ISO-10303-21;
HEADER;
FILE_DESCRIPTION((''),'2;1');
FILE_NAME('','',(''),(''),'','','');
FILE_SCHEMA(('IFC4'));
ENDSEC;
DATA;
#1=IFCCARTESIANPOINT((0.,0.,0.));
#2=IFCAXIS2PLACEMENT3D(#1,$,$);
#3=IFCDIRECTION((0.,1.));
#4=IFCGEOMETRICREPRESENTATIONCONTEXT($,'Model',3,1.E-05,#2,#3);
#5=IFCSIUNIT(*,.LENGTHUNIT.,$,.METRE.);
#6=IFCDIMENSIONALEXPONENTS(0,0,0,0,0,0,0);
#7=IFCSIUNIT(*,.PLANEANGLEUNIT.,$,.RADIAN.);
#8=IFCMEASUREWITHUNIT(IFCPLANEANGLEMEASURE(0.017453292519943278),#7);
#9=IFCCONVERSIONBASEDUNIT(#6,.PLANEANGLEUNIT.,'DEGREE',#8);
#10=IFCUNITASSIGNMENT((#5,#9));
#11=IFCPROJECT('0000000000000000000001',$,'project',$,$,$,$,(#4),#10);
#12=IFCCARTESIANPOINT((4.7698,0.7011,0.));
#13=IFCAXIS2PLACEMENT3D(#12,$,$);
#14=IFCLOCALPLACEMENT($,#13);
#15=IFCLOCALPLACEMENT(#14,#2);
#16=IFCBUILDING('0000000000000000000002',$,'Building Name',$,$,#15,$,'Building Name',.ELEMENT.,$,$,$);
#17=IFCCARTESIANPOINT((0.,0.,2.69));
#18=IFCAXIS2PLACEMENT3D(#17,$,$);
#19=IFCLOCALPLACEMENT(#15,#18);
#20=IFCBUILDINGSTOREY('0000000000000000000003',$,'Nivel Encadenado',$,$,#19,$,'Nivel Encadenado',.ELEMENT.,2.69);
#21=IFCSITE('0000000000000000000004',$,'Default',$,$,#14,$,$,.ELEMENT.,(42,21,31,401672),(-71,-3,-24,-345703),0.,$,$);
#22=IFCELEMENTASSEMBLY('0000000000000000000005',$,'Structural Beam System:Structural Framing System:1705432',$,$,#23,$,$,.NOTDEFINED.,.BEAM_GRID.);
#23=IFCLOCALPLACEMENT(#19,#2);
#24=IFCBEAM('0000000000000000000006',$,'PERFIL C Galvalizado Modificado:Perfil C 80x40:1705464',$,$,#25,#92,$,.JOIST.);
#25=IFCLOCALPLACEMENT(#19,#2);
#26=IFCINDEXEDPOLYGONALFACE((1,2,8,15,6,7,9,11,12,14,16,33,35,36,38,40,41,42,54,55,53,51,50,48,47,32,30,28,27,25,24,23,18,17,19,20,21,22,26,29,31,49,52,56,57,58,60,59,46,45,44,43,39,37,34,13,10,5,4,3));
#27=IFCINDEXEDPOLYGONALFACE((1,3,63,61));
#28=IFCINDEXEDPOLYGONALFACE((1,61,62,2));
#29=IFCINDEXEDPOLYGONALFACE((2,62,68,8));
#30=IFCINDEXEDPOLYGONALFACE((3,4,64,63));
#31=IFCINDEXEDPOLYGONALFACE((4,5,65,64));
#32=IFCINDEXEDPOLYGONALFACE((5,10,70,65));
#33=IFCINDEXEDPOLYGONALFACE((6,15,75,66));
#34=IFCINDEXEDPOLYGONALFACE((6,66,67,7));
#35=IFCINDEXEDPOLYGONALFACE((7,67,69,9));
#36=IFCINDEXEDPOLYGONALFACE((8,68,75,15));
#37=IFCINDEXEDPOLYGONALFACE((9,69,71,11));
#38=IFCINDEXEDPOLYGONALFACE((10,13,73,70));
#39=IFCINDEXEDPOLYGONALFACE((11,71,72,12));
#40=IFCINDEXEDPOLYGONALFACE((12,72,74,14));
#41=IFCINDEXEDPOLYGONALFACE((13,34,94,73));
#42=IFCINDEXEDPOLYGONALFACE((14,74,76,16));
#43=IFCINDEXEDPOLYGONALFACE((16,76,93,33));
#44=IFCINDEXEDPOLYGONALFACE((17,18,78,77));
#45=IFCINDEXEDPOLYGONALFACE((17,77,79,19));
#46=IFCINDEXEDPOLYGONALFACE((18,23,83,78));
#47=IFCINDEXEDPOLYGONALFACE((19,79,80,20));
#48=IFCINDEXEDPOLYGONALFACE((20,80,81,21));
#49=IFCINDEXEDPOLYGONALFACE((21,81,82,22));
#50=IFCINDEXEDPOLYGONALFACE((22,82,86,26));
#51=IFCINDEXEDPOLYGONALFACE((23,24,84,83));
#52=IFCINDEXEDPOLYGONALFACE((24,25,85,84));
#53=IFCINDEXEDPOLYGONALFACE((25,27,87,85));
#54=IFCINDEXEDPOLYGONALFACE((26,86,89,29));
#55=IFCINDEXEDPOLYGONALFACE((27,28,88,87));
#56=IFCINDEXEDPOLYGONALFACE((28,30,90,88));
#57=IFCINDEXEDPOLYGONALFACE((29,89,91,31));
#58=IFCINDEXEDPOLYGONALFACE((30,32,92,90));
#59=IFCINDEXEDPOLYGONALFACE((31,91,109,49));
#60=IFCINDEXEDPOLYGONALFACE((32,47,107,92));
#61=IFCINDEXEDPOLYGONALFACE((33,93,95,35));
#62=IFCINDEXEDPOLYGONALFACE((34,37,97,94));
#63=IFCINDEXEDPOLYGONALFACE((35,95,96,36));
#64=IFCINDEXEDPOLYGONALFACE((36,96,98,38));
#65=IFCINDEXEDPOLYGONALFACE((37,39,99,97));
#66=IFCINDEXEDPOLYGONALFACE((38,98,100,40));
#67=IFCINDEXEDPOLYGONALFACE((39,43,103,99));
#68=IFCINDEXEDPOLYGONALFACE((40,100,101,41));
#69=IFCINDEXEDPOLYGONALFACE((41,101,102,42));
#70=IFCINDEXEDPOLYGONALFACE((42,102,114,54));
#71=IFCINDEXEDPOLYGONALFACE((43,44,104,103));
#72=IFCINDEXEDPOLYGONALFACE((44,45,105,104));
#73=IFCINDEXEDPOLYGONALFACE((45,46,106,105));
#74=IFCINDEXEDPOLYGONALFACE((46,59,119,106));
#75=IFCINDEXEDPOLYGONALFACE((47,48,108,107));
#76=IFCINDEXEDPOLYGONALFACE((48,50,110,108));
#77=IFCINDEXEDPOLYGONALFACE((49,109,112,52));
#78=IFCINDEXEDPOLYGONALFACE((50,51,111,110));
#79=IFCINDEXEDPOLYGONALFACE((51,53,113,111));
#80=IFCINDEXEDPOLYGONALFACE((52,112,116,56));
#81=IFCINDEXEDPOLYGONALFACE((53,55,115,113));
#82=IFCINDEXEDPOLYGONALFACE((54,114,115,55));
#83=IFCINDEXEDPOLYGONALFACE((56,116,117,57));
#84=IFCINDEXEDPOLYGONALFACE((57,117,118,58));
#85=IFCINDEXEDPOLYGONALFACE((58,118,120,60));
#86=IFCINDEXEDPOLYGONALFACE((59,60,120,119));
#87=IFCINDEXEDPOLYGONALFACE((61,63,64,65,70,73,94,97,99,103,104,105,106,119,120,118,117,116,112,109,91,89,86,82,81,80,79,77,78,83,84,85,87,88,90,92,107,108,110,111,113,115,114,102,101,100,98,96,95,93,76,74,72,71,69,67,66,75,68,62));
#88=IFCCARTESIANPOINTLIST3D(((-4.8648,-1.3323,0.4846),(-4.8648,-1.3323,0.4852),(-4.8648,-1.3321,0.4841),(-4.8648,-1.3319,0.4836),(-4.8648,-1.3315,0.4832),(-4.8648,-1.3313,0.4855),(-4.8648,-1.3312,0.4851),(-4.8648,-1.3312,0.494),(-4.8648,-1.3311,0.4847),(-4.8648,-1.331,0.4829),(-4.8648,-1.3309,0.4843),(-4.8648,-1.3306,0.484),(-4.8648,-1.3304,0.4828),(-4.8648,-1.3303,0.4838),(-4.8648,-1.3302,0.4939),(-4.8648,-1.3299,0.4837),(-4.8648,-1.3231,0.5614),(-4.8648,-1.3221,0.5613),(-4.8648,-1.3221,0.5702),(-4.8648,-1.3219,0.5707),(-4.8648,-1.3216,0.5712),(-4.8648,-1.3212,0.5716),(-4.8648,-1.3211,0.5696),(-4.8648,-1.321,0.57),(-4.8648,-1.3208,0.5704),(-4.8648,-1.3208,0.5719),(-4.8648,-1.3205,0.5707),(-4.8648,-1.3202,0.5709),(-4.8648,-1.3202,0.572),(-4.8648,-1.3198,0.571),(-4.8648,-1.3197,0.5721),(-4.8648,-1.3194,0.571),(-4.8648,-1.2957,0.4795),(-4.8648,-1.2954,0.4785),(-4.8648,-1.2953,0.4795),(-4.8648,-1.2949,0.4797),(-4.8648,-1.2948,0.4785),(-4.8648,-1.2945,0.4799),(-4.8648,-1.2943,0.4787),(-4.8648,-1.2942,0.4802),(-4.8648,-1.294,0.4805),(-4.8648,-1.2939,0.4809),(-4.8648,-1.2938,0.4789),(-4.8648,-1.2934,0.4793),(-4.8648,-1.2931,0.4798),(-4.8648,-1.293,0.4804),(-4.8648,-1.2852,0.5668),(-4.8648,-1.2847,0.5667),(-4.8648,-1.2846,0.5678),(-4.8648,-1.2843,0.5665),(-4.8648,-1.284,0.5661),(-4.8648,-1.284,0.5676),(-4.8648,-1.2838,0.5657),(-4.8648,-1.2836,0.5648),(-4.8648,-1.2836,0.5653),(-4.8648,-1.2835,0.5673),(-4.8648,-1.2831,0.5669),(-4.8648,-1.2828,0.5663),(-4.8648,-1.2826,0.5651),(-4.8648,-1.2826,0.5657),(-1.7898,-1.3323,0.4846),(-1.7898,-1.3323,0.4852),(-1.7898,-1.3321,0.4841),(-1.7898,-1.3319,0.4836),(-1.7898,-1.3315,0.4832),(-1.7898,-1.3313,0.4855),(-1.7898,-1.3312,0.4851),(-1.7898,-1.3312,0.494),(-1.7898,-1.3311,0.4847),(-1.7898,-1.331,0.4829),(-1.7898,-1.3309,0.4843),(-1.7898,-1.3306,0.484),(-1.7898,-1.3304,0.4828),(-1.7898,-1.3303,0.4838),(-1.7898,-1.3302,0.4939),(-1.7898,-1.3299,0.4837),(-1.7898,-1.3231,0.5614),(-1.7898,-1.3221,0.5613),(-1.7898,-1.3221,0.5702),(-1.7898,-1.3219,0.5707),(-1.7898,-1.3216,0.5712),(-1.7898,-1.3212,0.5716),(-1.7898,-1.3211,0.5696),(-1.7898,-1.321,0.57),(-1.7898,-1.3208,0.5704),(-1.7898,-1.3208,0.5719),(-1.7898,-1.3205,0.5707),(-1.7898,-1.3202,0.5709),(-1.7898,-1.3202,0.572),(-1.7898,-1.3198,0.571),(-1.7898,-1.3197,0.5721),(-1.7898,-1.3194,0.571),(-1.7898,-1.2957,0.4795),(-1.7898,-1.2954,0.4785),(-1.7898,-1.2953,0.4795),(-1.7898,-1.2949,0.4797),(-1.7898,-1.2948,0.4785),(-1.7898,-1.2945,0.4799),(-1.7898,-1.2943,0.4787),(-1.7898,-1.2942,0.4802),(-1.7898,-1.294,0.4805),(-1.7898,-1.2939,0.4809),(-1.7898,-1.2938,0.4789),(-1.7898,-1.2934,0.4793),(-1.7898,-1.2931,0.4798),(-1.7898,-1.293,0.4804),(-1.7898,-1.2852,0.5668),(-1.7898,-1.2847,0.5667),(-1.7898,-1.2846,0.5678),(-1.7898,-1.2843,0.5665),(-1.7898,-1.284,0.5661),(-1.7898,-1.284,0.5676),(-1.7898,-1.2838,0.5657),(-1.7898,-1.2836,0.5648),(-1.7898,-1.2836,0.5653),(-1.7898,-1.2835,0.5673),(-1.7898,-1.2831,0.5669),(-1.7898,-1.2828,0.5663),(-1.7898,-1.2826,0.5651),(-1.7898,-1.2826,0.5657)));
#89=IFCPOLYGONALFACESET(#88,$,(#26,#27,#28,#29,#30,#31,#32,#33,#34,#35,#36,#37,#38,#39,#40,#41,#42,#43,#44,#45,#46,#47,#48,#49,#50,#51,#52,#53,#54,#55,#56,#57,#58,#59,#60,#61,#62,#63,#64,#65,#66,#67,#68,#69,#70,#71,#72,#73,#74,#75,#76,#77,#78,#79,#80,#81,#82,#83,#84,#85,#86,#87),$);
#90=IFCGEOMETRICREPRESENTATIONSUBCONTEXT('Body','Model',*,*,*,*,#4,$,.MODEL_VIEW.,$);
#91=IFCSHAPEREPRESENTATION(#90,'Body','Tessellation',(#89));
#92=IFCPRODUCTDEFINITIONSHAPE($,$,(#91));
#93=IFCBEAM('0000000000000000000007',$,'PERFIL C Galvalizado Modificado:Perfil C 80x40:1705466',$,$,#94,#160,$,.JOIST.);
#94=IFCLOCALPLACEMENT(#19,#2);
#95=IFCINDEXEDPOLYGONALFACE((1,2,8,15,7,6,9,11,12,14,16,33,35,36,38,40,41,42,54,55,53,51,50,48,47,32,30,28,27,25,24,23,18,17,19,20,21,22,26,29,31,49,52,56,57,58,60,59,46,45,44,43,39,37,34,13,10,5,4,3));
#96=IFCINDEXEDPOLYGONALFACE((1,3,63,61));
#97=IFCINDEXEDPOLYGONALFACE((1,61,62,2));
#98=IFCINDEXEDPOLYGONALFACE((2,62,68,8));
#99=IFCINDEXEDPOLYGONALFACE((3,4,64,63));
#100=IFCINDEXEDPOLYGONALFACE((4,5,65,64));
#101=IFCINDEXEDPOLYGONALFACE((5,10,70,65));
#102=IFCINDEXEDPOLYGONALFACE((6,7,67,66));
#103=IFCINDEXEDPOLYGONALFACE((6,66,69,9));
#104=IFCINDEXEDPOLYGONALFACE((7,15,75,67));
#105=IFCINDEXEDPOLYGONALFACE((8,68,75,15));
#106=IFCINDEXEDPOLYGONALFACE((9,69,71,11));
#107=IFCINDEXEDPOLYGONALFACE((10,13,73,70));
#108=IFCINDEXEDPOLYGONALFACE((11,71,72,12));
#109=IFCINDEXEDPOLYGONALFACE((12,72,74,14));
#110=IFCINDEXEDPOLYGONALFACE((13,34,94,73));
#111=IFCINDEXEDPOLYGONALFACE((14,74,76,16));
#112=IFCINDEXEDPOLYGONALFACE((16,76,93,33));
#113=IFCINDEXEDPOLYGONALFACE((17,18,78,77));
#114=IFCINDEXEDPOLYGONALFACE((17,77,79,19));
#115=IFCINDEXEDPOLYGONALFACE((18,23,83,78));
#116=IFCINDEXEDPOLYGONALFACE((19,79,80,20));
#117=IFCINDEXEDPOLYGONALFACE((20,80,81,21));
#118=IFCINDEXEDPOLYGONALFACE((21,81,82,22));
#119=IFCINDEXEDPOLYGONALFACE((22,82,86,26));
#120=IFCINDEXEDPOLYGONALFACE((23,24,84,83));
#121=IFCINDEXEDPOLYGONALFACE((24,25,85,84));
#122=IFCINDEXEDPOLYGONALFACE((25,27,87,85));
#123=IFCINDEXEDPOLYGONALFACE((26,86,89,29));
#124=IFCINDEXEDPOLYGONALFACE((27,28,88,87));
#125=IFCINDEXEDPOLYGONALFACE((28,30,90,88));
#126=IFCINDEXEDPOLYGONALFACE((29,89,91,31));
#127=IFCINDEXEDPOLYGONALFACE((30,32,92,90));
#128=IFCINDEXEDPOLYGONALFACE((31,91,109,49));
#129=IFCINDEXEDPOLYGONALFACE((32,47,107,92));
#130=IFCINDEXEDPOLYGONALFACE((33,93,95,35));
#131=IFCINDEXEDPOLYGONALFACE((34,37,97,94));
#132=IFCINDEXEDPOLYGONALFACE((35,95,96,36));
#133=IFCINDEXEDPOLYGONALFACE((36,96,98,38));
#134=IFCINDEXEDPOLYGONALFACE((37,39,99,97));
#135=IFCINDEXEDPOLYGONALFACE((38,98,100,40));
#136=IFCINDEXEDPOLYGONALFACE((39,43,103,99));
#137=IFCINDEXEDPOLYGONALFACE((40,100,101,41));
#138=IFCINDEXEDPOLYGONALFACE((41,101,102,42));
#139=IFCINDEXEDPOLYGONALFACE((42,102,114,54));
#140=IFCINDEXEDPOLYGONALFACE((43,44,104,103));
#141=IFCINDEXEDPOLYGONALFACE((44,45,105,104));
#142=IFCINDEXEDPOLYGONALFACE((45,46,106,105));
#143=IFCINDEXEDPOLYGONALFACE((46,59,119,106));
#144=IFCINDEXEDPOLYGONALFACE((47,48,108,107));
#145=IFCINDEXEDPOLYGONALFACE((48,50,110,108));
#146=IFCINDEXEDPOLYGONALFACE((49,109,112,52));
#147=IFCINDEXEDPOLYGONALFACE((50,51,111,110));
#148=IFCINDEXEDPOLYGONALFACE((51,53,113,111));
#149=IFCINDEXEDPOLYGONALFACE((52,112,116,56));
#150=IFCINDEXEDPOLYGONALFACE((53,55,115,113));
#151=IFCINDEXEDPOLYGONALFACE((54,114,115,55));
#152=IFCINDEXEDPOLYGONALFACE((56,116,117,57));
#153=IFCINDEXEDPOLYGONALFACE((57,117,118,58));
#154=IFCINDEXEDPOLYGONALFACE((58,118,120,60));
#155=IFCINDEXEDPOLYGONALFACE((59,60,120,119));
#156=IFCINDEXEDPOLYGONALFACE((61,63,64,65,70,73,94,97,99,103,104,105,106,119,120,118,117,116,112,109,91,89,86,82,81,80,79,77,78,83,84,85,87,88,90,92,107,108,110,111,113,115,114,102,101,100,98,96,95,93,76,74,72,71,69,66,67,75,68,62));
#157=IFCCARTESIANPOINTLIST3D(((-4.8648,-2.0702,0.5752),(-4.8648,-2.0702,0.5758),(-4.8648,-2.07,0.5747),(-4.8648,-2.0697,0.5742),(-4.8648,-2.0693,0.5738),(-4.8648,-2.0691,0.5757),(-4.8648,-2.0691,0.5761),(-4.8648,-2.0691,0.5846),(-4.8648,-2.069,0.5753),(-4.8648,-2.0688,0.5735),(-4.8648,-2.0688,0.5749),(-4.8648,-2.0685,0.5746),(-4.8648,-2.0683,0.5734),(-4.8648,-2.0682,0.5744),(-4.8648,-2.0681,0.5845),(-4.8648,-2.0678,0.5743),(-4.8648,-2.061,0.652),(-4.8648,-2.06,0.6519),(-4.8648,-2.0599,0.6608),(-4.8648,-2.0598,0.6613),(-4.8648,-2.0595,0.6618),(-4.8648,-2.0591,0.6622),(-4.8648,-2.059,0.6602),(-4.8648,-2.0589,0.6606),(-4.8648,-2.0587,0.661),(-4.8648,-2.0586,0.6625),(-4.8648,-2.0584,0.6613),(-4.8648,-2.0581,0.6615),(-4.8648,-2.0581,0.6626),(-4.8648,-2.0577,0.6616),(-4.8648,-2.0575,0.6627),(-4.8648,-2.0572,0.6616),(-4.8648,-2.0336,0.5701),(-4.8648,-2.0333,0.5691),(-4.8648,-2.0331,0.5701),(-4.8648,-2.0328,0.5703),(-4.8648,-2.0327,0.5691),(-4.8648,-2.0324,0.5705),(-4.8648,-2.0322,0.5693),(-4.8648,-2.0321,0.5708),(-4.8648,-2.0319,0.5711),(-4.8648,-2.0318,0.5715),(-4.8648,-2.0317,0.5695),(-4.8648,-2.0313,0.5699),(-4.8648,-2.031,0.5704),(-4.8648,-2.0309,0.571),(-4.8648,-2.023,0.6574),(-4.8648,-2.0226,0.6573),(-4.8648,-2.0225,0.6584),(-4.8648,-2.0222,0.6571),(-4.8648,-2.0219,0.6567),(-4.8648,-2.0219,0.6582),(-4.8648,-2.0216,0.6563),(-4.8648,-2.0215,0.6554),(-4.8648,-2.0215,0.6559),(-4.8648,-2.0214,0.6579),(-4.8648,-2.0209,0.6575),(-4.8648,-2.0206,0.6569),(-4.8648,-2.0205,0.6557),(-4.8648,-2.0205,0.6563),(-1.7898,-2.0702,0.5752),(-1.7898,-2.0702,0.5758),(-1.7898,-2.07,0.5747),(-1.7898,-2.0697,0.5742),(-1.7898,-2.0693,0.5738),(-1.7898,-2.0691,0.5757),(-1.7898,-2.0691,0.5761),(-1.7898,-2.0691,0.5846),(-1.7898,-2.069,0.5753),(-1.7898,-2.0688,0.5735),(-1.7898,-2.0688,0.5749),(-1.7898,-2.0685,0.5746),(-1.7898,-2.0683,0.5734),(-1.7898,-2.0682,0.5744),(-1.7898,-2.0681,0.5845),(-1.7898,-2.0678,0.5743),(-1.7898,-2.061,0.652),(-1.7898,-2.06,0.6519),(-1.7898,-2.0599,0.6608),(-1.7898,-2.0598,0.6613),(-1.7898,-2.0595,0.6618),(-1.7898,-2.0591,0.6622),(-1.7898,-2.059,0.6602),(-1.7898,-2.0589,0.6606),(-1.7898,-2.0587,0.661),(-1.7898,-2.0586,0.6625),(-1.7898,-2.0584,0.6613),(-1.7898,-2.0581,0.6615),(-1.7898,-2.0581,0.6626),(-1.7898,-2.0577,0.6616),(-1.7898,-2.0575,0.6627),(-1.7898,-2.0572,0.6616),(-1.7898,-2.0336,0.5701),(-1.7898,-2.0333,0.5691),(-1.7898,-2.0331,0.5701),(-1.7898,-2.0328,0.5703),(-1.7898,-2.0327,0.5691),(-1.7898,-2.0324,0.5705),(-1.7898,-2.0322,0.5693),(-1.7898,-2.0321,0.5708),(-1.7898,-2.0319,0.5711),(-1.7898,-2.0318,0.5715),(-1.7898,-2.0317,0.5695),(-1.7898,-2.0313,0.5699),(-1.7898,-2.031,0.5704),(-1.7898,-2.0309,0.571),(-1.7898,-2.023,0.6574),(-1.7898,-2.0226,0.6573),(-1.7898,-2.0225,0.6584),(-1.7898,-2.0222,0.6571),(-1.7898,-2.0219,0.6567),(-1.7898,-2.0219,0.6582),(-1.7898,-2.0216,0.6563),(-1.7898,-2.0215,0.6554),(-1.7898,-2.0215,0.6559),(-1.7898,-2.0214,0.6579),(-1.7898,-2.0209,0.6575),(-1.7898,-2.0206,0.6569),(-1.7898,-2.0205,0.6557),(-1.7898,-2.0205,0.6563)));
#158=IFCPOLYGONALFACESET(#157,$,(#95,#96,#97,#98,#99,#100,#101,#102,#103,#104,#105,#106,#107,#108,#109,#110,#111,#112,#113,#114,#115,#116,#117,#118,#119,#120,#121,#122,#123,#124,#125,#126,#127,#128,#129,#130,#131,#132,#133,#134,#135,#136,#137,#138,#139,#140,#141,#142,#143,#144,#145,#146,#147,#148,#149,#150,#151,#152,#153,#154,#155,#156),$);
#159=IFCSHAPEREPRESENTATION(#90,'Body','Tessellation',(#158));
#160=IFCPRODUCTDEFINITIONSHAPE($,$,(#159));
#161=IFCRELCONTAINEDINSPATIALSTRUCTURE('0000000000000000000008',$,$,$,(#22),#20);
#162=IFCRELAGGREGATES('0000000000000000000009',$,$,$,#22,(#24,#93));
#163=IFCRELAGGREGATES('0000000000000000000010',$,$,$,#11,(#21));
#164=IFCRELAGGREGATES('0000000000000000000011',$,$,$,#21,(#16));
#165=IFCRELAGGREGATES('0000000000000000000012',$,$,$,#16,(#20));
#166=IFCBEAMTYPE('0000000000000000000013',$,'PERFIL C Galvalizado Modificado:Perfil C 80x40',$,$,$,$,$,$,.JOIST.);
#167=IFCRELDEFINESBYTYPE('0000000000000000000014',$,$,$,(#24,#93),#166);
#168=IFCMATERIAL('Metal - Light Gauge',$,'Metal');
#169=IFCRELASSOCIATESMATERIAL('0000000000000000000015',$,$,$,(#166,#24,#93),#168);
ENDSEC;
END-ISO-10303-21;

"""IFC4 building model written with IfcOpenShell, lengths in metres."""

from ifc_helpers import new_model, entity, si_unit, converted_unit, direction, frame, origin, place, context, subcontext, project, spatial, line, arc, indexed_curve, outline, extrude, source, transform, mapped, material, type_object, type_shapes, element, aggregate, save


model = new_model("IFC4")

# Units and contexts
model_context = context("Model", 3, precision=1e-05, world=origin(), true_north=direction((0.0, 1.0)))
body_context = subcontext(model_context, "Body", "Model", "MODEL_VIEW")
ifc_project = project(units=[si_unit("LENGTHUNIT", "METRE"), converted_unit("PLANEANGLEUNIT", "DEGREE", entity("IfcPlaneAngleMeasure", 0.017453292519943278), si_unit("PLANEANGLEUNIT", "RADIAN"), dimensions=[0, 0, 0, 0, 0, 0, 0])], contexts=[model_context])

# Site, building, storey
site_placement = place(None, frame((4.7698, 0.7011, 0.0)))
site = spatial("IfcSite", under=ifc_project, at=site_placement, Name="Default", CompositionType="ELEMENT", RefLatitude=(42, 21, 31, 401672), RefLongitude=(-71, -3, -24, -345703), RefElevation=0.0)
building_placement = place(site_placement, origin())
building = spatial("IfcBuilding", under=site, at=building_placement, Name="Building Name", LongName="Building Name", CompositionType="ELEMENT")
storey_placement = place(building_placement, frame((0.0, 0.0, 2.69)))
storey = spatial("IfcBuildingStorey", under=building, at=storey_placement, Name="Nivel Encadenado", LongName="Nivel Encadenado", CompositionType="ELEMENT", Elevation=2.69)

# Element assembly, beams
ifc_material_1 = material(Name="Metal - Light Gauge", Category="Metal")
assembly_1_placement = place(storey_placement, origin())
assembly_1 = element("IfcElementAssembly", 1, at=assembly_1_placement, inside=storey, Name="Structural Beam System:Structural Framing System:1705432", AssemblyPlace="NOTDEFINED", PredefinedType="BEAM_GRID")
beam_type_1 = type_object("IfcBeamType", Name="PERFIL C Galvalizado Modificado:Perfil C 80x40", PredefinedType="JOIST", material=ifc_material_1)
shared_shape_1 = source(origin(), body_context, "Body", "SweptSolid", [
    extrude(outline(indexed_curve([(-0.0428, -0.0161), (-0.034, -0.0161), (-0.034, -0.0151), (-0.0424, -0.0151), (-0.0435, -0.0146), (-0.044, -0.0135), (-0.044, 0.021), (-0.0435, 0.0222), (-0.0422, 0.0227), (0.0424, 0.0227), (0.0435, 0.0223), (0.0439, 0.0212), (0.0439, -0.0133), (0.0435, -0.0144), (0.0424, -0.0149), (0.0339, -0.0149), (0.0339, -0.0159), (0.0428, -0.0159), (0.0443, -0.0152), (0.0449, -0.0137), (0.0449, 0.0216), (0.0443, 0.0231), (0.0428, 0.0237), (-0.0426, 0.0237), (-0.0443, 0.023), (-0.045, 0.0214), (-0.045, -0.0139), (-0.0443, -0.0154)], segments=[line(1, 2, 3, 4), arc(4, 5, 6), line(6, 7), arc(7, 8, 9), line(9, 10), arc(10, 11, 12), line(12, 13), arc(13, 14, 15), line(15, 16, 17, 18), arc(18, 19, 20), line(20, 21), arc(21, 22, 23), line(23, 24), arc(24, 25, 26), line(26, 27), arc(27, 28, 1)], self_intersect=False)), frame((-1.5375, -0.0037, 0.0), z_axis=(1.0, 0.0, 0.0), x_axis=(0.0, 0.0, -1.0)), (0.0, 0.0, 1.0), 3.075),
])
type_shapes(beam_type_1, [shared_shape_1])
beam_1_placement = place(assembly_1_placement, frame((-3.3273, -1.3076, 0.5253), z_axis=(0.0, 0.121869, 0.992546), x_axis=(1.0, 0.0, 0.0)))
beam_1 = element("IfcBeam", 2, at=beam_1_placement, type_object=beam_type_1, material=ifc_material_1, Name="PERFIL C Galvalizado Modificado:Perfil C 80x40:1705464", PredefinedType="JOIST", context=body_context, shape_type="MappedRepresentation", body=[
    mapped(shared_shape_1, transform((0.0, 0.0, 0.0), scale=1.0)),
])
beam_2_placement = place(assembly_1_placement, frame((-3.3273, -2.0455, 0.6159), z_axis=(0.0, 0.121869, 0.992546), x_axis=(1.0, 0.0, 0.0)))
beam_2 = element("IfcBeam", 3, at=beam_2_placement, type_object=beam_type_1, material=ifc_material_1, Name="PERFIL C Galvalizado Modificado:Perfil C 80x40:1705466", PredefinedType="JOIST", context=body_context, shape_type="MappedRepresentation", body=[
    mapped(shared_shape_1, transform((0.0, 0.0, 0.0), scale=1.0)),
])
aggregate(assembly_1, [beam_1, beam_2])

save(model, "model.ifc")
